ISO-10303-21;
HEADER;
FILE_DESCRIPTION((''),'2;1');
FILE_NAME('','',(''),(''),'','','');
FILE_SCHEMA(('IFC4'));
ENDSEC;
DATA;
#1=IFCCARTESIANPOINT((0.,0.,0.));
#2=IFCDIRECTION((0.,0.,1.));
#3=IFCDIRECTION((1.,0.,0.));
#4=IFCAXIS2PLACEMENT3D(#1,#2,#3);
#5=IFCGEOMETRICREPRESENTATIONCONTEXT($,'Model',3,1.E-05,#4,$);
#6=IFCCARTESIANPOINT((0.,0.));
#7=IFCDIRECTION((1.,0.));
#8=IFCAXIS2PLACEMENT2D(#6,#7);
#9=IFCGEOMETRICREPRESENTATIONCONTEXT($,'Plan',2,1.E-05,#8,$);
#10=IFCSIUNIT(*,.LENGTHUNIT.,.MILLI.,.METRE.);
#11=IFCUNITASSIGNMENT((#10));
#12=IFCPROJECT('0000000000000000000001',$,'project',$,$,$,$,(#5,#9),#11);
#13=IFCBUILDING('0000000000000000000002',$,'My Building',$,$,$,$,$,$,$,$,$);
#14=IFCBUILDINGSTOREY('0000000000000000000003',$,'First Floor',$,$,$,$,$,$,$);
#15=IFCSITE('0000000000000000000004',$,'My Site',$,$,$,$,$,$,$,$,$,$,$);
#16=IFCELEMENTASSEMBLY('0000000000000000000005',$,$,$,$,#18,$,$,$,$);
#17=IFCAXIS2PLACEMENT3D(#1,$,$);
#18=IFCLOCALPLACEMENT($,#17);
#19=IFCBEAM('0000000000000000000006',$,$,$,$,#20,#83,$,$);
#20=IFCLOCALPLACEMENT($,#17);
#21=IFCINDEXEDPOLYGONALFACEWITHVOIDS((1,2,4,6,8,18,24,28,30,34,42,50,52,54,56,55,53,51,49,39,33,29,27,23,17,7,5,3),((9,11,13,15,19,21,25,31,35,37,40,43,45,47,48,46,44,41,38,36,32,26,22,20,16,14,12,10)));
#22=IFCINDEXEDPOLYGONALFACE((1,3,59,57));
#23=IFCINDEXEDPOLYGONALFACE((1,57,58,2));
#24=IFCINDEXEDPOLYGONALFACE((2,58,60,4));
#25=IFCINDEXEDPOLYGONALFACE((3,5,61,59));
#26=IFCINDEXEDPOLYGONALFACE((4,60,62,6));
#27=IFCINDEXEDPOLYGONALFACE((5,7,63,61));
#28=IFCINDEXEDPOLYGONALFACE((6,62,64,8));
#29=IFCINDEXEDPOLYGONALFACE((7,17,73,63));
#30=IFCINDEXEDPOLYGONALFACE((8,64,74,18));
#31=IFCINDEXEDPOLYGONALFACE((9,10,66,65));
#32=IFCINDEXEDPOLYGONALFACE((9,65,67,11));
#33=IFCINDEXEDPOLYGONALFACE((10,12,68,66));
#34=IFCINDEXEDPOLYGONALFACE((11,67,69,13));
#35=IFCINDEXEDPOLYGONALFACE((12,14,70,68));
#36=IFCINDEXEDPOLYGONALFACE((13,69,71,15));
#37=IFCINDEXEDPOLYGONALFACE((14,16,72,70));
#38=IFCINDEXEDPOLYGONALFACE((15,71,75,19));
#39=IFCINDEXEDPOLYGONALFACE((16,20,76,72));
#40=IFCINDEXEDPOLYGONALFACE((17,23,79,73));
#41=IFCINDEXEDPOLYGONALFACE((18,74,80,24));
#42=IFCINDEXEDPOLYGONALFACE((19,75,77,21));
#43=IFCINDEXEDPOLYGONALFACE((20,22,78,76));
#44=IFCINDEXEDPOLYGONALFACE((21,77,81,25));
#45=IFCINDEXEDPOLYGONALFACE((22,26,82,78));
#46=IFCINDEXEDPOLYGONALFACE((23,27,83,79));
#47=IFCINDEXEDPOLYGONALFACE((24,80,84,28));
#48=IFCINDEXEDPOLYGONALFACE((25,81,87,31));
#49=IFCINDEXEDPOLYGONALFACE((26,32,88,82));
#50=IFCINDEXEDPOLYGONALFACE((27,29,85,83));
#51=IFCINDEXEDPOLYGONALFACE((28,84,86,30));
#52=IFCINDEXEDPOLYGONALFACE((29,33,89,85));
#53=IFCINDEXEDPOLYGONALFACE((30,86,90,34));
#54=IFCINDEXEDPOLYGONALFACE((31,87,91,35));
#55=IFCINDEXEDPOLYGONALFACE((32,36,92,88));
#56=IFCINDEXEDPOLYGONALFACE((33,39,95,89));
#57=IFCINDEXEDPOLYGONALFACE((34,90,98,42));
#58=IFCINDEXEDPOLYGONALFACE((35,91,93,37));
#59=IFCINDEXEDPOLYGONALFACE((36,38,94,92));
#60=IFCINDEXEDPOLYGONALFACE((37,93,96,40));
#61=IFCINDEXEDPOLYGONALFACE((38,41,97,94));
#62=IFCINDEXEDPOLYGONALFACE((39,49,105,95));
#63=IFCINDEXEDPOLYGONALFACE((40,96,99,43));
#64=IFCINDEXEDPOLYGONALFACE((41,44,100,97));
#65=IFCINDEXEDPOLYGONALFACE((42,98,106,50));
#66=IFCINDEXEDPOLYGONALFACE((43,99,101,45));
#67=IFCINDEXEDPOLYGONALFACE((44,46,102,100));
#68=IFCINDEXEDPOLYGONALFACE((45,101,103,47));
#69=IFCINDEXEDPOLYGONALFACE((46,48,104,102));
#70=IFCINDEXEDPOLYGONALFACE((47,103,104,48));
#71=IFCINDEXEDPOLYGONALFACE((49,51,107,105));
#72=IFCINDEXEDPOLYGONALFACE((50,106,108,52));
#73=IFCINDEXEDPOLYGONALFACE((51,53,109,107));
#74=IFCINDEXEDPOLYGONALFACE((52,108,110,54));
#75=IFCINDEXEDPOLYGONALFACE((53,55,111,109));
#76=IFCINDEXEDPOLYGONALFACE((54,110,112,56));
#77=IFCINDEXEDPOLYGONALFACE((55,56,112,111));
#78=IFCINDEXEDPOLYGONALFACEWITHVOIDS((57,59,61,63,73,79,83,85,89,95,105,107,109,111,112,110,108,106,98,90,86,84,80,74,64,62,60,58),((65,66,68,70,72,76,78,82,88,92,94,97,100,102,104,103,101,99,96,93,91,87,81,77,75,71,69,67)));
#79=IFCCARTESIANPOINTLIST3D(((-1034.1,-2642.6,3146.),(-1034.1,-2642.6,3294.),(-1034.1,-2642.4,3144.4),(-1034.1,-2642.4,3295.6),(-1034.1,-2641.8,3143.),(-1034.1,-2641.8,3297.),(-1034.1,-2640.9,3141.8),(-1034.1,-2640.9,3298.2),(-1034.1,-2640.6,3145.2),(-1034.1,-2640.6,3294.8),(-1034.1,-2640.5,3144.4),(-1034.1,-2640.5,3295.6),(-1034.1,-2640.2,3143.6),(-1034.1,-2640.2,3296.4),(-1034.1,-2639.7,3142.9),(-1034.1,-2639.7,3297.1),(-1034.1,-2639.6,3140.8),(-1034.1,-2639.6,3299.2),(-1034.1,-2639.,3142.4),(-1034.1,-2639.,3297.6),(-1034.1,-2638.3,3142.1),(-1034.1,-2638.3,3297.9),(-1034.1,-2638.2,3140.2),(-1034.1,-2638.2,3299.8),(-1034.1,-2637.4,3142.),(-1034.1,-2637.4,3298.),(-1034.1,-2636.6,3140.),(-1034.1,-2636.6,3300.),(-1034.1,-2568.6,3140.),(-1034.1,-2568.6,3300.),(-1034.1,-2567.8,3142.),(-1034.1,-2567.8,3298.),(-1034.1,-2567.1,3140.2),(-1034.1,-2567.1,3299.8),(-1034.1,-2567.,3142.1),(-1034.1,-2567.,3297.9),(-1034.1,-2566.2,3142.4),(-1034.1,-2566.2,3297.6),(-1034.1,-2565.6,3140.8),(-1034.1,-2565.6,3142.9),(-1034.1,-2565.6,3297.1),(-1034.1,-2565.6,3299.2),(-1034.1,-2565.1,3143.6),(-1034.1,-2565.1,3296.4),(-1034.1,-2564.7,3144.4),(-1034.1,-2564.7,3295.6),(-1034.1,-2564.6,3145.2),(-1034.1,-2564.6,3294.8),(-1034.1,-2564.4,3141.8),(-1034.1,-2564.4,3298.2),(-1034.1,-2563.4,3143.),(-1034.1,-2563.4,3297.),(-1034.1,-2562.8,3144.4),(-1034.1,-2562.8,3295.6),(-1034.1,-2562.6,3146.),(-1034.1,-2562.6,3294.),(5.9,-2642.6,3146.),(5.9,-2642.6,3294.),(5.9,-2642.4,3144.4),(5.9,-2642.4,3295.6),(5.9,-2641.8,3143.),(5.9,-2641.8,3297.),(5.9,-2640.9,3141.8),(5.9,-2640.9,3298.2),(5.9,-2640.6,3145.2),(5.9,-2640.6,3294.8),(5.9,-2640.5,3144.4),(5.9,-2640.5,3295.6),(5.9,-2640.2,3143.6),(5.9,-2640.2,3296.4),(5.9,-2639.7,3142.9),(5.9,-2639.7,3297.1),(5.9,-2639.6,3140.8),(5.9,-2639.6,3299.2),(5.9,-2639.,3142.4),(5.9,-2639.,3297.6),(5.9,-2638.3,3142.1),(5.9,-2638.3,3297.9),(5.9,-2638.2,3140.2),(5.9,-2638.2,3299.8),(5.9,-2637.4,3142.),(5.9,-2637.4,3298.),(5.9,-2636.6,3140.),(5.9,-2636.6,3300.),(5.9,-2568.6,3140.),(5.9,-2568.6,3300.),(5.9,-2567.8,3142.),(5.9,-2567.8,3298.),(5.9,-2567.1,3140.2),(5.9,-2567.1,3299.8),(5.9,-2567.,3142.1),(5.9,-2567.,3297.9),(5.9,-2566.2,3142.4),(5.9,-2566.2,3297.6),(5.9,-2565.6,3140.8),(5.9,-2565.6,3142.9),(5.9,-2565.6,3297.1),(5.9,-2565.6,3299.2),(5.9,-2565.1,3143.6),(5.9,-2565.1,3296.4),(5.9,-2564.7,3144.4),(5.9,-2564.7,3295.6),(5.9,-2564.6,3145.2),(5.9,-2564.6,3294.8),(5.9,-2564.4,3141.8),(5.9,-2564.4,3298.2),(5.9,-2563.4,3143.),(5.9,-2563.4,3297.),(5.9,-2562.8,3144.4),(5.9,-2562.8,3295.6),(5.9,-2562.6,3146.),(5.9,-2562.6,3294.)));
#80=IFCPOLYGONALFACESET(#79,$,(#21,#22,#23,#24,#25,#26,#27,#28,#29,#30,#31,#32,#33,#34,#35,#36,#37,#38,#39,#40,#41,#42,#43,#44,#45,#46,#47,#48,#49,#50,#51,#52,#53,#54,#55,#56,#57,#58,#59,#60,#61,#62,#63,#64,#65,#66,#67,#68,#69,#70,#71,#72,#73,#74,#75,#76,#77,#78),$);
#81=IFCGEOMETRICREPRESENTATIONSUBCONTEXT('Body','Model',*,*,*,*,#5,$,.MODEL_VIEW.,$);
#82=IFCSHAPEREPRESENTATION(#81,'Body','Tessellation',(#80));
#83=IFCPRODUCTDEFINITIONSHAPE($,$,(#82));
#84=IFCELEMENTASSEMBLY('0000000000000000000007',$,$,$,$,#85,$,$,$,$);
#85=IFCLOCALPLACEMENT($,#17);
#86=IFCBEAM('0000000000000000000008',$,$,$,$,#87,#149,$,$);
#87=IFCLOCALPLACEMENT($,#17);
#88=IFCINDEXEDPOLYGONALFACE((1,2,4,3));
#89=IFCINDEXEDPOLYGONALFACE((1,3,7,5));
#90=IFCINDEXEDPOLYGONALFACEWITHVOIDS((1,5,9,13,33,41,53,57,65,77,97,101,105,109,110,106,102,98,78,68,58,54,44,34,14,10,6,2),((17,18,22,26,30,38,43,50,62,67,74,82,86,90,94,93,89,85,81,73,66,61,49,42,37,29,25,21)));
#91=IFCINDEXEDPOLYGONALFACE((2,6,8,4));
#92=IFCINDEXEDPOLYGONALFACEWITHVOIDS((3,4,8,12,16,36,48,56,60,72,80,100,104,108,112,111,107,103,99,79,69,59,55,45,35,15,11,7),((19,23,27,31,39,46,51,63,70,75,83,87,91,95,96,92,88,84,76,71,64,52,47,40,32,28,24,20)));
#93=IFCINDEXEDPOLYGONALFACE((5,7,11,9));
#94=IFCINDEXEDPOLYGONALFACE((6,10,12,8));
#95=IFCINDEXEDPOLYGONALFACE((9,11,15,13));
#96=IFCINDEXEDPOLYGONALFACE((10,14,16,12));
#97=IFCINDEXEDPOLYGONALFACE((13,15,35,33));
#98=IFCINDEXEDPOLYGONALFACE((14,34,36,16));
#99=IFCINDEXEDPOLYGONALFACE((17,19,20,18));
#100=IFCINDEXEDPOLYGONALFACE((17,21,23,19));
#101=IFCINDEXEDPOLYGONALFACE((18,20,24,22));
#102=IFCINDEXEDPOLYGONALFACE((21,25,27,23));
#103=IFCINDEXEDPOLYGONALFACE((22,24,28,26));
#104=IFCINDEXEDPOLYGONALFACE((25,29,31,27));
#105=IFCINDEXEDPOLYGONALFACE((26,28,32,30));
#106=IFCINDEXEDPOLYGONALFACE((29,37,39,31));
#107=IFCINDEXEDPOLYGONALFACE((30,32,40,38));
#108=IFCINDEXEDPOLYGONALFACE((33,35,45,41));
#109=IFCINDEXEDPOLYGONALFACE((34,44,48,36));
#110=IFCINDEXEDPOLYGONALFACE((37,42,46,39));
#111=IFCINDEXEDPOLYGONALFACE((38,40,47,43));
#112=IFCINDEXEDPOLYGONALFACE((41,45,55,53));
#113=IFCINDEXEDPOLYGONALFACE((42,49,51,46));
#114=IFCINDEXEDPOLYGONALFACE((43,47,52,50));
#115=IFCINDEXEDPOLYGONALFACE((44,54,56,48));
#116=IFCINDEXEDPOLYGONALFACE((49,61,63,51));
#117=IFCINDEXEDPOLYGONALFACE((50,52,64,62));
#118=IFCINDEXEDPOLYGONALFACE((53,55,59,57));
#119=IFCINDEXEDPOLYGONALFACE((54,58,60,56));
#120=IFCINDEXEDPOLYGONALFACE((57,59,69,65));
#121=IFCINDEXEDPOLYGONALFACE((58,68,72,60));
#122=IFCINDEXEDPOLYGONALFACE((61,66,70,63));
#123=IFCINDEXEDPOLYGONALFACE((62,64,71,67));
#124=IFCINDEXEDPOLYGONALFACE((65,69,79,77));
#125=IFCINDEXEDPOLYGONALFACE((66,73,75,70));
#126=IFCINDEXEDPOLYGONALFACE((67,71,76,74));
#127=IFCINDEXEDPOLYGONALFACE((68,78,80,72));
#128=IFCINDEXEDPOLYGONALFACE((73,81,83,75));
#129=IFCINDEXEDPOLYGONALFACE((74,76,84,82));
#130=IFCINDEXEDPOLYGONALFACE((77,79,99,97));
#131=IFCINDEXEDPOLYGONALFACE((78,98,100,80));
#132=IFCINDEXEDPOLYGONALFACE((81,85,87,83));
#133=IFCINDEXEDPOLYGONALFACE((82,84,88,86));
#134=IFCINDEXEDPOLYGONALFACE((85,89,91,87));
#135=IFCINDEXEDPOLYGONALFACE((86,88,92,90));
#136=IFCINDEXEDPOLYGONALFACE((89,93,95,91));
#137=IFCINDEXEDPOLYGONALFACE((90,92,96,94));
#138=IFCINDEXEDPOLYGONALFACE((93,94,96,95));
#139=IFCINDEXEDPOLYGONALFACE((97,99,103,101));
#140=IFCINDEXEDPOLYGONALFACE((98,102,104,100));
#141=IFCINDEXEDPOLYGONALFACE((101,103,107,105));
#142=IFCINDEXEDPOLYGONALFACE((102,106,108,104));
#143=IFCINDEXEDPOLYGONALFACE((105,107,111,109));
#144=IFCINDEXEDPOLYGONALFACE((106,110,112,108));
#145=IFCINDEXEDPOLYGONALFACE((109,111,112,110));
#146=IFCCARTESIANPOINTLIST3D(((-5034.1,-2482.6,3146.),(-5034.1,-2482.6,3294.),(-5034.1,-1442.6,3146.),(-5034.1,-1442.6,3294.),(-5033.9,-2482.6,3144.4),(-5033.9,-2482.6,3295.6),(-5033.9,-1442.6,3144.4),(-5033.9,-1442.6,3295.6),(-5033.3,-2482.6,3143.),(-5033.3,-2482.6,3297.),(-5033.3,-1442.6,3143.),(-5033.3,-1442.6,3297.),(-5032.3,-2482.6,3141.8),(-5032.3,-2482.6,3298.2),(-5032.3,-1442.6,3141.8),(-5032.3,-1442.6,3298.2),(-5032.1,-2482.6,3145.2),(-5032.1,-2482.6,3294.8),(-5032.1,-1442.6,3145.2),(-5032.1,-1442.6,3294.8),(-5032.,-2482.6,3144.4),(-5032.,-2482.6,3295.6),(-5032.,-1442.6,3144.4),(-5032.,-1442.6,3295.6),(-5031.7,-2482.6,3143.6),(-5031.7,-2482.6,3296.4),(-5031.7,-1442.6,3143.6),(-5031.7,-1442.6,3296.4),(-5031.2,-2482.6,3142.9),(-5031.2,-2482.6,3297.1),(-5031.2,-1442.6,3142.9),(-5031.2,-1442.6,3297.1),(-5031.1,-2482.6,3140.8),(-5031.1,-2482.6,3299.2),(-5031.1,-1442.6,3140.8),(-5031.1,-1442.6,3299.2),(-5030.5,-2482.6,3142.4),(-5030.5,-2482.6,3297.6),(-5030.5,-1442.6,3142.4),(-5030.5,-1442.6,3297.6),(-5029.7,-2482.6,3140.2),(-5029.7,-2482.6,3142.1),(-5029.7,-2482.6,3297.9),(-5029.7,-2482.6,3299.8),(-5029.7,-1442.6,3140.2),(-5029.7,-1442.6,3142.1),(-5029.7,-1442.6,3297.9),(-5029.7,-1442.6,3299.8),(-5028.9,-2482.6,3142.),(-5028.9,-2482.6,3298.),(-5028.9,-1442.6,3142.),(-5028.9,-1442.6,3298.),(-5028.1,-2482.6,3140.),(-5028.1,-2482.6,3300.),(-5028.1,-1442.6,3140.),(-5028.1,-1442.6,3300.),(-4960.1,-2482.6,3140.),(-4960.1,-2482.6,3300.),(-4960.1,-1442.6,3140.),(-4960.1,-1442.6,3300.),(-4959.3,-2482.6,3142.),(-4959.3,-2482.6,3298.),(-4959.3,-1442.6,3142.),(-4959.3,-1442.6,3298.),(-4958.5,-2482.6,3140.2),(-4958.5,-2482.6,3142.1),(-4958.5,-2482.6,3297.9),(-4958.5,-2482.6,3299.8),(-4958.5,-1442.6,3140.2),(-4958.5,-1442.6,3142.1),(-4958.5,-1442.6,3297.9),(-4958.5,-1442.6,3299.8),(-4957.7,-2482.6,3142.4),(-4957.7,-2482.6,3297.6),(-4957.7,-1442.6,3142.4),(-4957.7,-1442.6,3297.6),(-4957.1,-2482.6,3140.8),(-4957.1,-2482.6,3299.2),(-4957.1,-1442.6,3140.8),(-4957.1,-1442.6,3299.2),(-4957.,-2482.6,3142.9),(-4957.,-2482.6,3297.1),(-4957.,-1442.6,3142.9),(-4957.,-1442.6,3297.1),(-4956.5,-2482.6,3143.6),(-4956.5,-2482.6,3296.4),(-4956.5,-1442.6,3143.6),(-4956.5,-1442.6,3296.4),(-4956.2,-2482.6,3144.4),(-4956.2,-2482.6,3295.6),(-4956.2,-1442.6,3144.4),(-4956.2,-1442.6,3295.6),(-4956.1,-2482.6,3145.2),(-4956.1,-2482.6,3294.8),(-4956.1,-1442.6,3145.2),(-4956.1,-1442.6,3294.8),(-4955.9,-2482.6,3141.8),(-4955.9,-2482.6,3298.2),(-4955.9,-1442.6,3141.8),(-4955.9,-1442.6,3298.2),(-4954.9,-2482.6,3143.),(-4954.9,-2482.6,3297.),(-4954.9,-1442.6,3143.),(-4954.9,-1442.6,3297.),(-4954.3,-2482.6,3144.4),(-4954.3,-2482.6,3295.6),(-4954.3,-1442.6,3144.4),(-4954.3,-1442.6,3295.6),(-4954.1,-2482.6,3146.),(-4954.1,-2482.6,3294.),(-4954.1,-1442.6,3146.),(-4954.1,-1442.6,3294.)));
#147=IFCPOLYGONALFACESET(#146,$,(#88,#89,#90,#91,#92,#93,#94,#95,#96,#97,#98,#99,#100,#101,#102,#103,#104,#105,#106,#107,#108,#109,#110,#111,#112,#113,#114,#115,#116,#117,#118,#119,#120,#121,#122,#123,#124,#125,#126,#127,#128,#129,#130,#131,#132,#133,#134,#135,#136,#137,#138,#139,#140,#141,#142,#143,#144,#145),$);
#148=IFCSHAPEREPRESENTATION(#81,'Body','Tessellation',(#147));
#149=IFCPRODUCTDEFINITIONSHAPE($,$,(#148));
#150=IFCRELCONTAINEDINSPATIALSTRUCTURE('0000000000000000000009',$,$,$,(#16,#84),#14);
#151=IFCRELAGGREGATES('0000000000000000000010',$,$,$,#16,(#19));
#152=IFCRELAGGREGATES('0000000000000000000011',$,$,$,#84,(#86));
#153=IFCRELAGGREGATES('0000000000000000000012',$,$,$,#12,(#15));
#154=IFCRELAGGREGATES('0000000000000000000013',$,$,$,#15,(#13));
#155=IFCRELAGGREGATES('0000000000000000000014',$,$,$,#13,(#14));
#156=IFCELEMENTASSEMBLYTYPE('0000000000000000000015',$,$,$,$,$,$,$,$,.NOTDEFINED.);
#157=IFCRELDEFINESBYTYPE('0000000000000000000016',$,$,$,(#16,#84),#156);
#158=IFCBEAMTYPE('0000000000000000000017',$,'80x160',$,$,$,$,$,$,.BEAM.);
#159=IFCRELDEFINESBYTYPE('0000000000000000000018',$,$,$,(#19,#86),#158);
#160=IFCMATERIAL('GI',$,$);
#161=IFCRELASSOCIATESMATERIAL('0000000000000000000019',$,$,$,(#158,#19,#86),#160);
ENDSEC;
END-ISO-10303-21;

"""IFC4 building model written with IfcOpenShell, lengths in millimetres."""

from ifc_helpers import new_model, si_unit, frame, origin_with_axes, origin_2d_with_axis, place, context, subcontext, project, spatial, hollow_rectangle, extrude, material, material_profile, profile_set, profile_usage, type_object, element, aggregate, save


model = new_model("IFC4")

# Units and contexts
model_context = context("Model", 3, precision=1e-05, world=origin_with_axes())
plan_context = context("Plan", 2, precision=1e-05, world=origin_2d_with_axis())
body_context = subcontext(model_context, "Body", "Model", "MODEL_VIEW")
ifc_project = project(units=[si_unit("LENGTHUNIT", "METRE", prefix="MILLI")], contexts=[model_context, plan_context])

# Site, building, storey
site = spatial("IfcSite", under=ifc_project, Name="My Site")
building = spatial("IfcBuilding", under=site, Name="My Building")
storey = spatial("IfcBuildingStorey", under=building, Name="First Floor")

# Element assemblies, beams
element_assembly_type = type_object("IfcElementAssemblyType", PredefinedType="NOTDEFINED")
ifc_material = material(Name="GI")
ifc_material_profile = material_profile(ifc_material, hollow_rectangle(XDim=80.0, YDim=160.0, WallThickness=2.0, InnerFilletRadius=3.2, OuterFilletRadius=6.0))
ifc_profile_set = profile_set([ifc_material_profile], Name="80x160 GI Rectangular Hollow")
beam_type = type_object("IfcBeamType", Name="80x160", PredefinedType="BEAM", material=ifc_profile_set)
assembly_1_placement = place(None, frame((-1114.1, -2602.6, 3220.0), z_axis=(1.0, 0.0, 0.0), x_axis=(0.0, 1.0, 0.0)))
assembly_1 = element("IfcElementAssembly", 1, at=assembly_1_placement, inside=storey, type_object=element_assembly_type)
ifc_profile_usage_1 = profile_usage(ifc_profile_set)
beam_1_placement = place(assembly_1_placement, frame((0.0, 0.0, 80.0), z_axis=(0.0, 0.0, 1.0), x_axis=(1.0, 0.0, 0.0)))
beam_1 = element("IfcBeam", 2, at=beam_1_placement, type_object=beam_type, material=ifc_profile_usage_1, context=body_context, shape_type="SweptSolid", body=[
    extrude(hollow_rectangle(XDim=80.0, YDim=160.0, WallThickness=2.0, InnerFilletRadius=3.2, OuterFilletRadius=6.0), origin_with_axes(), (0.0, 0.0, 1.0), 1040.0),
])
aggregate(assembly_1, [beam_1])
assembly_2_placement = place(None, frame((-4994.1, -2562.6, 3220.0), z_axis=(0.0, 1.0, 0.0), x_axis=(1.0, 0.0, 0.0)))
assembly_2 = element("IfcElementAssembly", 3, at=assembly_2_placement, inside=storey, type_object=element_assembly_type)
ifc_profile_usage_2 = profile_usage(ifc_profile_set)
beam_2_placement = place(assembly_2_placement, frame((0.0, 0.0, 80.0), z_axis=(0.0, 0.0, 1.0), x_axis=(1.0, 0.0, 0.0)))
beam_2 = element("IfcBeam", 4, at=beam_2_placement, type_object=beam_type, material=ifc_profile_usage_2, context=body_context, shape_type="SweptSolid", body=[
    extrude(hollow_rectangle(XDim=80.0, YDim=160.0, WallThickness=2.0, InnerFilletRadius=3.2, OuterFilletRadius=6.0), origin_with_axes(), (0.0, 0.0, 1.0), 1040.0),
])
aggregate(assembly_2, [beam_2])

save(model, "model.ifc")
